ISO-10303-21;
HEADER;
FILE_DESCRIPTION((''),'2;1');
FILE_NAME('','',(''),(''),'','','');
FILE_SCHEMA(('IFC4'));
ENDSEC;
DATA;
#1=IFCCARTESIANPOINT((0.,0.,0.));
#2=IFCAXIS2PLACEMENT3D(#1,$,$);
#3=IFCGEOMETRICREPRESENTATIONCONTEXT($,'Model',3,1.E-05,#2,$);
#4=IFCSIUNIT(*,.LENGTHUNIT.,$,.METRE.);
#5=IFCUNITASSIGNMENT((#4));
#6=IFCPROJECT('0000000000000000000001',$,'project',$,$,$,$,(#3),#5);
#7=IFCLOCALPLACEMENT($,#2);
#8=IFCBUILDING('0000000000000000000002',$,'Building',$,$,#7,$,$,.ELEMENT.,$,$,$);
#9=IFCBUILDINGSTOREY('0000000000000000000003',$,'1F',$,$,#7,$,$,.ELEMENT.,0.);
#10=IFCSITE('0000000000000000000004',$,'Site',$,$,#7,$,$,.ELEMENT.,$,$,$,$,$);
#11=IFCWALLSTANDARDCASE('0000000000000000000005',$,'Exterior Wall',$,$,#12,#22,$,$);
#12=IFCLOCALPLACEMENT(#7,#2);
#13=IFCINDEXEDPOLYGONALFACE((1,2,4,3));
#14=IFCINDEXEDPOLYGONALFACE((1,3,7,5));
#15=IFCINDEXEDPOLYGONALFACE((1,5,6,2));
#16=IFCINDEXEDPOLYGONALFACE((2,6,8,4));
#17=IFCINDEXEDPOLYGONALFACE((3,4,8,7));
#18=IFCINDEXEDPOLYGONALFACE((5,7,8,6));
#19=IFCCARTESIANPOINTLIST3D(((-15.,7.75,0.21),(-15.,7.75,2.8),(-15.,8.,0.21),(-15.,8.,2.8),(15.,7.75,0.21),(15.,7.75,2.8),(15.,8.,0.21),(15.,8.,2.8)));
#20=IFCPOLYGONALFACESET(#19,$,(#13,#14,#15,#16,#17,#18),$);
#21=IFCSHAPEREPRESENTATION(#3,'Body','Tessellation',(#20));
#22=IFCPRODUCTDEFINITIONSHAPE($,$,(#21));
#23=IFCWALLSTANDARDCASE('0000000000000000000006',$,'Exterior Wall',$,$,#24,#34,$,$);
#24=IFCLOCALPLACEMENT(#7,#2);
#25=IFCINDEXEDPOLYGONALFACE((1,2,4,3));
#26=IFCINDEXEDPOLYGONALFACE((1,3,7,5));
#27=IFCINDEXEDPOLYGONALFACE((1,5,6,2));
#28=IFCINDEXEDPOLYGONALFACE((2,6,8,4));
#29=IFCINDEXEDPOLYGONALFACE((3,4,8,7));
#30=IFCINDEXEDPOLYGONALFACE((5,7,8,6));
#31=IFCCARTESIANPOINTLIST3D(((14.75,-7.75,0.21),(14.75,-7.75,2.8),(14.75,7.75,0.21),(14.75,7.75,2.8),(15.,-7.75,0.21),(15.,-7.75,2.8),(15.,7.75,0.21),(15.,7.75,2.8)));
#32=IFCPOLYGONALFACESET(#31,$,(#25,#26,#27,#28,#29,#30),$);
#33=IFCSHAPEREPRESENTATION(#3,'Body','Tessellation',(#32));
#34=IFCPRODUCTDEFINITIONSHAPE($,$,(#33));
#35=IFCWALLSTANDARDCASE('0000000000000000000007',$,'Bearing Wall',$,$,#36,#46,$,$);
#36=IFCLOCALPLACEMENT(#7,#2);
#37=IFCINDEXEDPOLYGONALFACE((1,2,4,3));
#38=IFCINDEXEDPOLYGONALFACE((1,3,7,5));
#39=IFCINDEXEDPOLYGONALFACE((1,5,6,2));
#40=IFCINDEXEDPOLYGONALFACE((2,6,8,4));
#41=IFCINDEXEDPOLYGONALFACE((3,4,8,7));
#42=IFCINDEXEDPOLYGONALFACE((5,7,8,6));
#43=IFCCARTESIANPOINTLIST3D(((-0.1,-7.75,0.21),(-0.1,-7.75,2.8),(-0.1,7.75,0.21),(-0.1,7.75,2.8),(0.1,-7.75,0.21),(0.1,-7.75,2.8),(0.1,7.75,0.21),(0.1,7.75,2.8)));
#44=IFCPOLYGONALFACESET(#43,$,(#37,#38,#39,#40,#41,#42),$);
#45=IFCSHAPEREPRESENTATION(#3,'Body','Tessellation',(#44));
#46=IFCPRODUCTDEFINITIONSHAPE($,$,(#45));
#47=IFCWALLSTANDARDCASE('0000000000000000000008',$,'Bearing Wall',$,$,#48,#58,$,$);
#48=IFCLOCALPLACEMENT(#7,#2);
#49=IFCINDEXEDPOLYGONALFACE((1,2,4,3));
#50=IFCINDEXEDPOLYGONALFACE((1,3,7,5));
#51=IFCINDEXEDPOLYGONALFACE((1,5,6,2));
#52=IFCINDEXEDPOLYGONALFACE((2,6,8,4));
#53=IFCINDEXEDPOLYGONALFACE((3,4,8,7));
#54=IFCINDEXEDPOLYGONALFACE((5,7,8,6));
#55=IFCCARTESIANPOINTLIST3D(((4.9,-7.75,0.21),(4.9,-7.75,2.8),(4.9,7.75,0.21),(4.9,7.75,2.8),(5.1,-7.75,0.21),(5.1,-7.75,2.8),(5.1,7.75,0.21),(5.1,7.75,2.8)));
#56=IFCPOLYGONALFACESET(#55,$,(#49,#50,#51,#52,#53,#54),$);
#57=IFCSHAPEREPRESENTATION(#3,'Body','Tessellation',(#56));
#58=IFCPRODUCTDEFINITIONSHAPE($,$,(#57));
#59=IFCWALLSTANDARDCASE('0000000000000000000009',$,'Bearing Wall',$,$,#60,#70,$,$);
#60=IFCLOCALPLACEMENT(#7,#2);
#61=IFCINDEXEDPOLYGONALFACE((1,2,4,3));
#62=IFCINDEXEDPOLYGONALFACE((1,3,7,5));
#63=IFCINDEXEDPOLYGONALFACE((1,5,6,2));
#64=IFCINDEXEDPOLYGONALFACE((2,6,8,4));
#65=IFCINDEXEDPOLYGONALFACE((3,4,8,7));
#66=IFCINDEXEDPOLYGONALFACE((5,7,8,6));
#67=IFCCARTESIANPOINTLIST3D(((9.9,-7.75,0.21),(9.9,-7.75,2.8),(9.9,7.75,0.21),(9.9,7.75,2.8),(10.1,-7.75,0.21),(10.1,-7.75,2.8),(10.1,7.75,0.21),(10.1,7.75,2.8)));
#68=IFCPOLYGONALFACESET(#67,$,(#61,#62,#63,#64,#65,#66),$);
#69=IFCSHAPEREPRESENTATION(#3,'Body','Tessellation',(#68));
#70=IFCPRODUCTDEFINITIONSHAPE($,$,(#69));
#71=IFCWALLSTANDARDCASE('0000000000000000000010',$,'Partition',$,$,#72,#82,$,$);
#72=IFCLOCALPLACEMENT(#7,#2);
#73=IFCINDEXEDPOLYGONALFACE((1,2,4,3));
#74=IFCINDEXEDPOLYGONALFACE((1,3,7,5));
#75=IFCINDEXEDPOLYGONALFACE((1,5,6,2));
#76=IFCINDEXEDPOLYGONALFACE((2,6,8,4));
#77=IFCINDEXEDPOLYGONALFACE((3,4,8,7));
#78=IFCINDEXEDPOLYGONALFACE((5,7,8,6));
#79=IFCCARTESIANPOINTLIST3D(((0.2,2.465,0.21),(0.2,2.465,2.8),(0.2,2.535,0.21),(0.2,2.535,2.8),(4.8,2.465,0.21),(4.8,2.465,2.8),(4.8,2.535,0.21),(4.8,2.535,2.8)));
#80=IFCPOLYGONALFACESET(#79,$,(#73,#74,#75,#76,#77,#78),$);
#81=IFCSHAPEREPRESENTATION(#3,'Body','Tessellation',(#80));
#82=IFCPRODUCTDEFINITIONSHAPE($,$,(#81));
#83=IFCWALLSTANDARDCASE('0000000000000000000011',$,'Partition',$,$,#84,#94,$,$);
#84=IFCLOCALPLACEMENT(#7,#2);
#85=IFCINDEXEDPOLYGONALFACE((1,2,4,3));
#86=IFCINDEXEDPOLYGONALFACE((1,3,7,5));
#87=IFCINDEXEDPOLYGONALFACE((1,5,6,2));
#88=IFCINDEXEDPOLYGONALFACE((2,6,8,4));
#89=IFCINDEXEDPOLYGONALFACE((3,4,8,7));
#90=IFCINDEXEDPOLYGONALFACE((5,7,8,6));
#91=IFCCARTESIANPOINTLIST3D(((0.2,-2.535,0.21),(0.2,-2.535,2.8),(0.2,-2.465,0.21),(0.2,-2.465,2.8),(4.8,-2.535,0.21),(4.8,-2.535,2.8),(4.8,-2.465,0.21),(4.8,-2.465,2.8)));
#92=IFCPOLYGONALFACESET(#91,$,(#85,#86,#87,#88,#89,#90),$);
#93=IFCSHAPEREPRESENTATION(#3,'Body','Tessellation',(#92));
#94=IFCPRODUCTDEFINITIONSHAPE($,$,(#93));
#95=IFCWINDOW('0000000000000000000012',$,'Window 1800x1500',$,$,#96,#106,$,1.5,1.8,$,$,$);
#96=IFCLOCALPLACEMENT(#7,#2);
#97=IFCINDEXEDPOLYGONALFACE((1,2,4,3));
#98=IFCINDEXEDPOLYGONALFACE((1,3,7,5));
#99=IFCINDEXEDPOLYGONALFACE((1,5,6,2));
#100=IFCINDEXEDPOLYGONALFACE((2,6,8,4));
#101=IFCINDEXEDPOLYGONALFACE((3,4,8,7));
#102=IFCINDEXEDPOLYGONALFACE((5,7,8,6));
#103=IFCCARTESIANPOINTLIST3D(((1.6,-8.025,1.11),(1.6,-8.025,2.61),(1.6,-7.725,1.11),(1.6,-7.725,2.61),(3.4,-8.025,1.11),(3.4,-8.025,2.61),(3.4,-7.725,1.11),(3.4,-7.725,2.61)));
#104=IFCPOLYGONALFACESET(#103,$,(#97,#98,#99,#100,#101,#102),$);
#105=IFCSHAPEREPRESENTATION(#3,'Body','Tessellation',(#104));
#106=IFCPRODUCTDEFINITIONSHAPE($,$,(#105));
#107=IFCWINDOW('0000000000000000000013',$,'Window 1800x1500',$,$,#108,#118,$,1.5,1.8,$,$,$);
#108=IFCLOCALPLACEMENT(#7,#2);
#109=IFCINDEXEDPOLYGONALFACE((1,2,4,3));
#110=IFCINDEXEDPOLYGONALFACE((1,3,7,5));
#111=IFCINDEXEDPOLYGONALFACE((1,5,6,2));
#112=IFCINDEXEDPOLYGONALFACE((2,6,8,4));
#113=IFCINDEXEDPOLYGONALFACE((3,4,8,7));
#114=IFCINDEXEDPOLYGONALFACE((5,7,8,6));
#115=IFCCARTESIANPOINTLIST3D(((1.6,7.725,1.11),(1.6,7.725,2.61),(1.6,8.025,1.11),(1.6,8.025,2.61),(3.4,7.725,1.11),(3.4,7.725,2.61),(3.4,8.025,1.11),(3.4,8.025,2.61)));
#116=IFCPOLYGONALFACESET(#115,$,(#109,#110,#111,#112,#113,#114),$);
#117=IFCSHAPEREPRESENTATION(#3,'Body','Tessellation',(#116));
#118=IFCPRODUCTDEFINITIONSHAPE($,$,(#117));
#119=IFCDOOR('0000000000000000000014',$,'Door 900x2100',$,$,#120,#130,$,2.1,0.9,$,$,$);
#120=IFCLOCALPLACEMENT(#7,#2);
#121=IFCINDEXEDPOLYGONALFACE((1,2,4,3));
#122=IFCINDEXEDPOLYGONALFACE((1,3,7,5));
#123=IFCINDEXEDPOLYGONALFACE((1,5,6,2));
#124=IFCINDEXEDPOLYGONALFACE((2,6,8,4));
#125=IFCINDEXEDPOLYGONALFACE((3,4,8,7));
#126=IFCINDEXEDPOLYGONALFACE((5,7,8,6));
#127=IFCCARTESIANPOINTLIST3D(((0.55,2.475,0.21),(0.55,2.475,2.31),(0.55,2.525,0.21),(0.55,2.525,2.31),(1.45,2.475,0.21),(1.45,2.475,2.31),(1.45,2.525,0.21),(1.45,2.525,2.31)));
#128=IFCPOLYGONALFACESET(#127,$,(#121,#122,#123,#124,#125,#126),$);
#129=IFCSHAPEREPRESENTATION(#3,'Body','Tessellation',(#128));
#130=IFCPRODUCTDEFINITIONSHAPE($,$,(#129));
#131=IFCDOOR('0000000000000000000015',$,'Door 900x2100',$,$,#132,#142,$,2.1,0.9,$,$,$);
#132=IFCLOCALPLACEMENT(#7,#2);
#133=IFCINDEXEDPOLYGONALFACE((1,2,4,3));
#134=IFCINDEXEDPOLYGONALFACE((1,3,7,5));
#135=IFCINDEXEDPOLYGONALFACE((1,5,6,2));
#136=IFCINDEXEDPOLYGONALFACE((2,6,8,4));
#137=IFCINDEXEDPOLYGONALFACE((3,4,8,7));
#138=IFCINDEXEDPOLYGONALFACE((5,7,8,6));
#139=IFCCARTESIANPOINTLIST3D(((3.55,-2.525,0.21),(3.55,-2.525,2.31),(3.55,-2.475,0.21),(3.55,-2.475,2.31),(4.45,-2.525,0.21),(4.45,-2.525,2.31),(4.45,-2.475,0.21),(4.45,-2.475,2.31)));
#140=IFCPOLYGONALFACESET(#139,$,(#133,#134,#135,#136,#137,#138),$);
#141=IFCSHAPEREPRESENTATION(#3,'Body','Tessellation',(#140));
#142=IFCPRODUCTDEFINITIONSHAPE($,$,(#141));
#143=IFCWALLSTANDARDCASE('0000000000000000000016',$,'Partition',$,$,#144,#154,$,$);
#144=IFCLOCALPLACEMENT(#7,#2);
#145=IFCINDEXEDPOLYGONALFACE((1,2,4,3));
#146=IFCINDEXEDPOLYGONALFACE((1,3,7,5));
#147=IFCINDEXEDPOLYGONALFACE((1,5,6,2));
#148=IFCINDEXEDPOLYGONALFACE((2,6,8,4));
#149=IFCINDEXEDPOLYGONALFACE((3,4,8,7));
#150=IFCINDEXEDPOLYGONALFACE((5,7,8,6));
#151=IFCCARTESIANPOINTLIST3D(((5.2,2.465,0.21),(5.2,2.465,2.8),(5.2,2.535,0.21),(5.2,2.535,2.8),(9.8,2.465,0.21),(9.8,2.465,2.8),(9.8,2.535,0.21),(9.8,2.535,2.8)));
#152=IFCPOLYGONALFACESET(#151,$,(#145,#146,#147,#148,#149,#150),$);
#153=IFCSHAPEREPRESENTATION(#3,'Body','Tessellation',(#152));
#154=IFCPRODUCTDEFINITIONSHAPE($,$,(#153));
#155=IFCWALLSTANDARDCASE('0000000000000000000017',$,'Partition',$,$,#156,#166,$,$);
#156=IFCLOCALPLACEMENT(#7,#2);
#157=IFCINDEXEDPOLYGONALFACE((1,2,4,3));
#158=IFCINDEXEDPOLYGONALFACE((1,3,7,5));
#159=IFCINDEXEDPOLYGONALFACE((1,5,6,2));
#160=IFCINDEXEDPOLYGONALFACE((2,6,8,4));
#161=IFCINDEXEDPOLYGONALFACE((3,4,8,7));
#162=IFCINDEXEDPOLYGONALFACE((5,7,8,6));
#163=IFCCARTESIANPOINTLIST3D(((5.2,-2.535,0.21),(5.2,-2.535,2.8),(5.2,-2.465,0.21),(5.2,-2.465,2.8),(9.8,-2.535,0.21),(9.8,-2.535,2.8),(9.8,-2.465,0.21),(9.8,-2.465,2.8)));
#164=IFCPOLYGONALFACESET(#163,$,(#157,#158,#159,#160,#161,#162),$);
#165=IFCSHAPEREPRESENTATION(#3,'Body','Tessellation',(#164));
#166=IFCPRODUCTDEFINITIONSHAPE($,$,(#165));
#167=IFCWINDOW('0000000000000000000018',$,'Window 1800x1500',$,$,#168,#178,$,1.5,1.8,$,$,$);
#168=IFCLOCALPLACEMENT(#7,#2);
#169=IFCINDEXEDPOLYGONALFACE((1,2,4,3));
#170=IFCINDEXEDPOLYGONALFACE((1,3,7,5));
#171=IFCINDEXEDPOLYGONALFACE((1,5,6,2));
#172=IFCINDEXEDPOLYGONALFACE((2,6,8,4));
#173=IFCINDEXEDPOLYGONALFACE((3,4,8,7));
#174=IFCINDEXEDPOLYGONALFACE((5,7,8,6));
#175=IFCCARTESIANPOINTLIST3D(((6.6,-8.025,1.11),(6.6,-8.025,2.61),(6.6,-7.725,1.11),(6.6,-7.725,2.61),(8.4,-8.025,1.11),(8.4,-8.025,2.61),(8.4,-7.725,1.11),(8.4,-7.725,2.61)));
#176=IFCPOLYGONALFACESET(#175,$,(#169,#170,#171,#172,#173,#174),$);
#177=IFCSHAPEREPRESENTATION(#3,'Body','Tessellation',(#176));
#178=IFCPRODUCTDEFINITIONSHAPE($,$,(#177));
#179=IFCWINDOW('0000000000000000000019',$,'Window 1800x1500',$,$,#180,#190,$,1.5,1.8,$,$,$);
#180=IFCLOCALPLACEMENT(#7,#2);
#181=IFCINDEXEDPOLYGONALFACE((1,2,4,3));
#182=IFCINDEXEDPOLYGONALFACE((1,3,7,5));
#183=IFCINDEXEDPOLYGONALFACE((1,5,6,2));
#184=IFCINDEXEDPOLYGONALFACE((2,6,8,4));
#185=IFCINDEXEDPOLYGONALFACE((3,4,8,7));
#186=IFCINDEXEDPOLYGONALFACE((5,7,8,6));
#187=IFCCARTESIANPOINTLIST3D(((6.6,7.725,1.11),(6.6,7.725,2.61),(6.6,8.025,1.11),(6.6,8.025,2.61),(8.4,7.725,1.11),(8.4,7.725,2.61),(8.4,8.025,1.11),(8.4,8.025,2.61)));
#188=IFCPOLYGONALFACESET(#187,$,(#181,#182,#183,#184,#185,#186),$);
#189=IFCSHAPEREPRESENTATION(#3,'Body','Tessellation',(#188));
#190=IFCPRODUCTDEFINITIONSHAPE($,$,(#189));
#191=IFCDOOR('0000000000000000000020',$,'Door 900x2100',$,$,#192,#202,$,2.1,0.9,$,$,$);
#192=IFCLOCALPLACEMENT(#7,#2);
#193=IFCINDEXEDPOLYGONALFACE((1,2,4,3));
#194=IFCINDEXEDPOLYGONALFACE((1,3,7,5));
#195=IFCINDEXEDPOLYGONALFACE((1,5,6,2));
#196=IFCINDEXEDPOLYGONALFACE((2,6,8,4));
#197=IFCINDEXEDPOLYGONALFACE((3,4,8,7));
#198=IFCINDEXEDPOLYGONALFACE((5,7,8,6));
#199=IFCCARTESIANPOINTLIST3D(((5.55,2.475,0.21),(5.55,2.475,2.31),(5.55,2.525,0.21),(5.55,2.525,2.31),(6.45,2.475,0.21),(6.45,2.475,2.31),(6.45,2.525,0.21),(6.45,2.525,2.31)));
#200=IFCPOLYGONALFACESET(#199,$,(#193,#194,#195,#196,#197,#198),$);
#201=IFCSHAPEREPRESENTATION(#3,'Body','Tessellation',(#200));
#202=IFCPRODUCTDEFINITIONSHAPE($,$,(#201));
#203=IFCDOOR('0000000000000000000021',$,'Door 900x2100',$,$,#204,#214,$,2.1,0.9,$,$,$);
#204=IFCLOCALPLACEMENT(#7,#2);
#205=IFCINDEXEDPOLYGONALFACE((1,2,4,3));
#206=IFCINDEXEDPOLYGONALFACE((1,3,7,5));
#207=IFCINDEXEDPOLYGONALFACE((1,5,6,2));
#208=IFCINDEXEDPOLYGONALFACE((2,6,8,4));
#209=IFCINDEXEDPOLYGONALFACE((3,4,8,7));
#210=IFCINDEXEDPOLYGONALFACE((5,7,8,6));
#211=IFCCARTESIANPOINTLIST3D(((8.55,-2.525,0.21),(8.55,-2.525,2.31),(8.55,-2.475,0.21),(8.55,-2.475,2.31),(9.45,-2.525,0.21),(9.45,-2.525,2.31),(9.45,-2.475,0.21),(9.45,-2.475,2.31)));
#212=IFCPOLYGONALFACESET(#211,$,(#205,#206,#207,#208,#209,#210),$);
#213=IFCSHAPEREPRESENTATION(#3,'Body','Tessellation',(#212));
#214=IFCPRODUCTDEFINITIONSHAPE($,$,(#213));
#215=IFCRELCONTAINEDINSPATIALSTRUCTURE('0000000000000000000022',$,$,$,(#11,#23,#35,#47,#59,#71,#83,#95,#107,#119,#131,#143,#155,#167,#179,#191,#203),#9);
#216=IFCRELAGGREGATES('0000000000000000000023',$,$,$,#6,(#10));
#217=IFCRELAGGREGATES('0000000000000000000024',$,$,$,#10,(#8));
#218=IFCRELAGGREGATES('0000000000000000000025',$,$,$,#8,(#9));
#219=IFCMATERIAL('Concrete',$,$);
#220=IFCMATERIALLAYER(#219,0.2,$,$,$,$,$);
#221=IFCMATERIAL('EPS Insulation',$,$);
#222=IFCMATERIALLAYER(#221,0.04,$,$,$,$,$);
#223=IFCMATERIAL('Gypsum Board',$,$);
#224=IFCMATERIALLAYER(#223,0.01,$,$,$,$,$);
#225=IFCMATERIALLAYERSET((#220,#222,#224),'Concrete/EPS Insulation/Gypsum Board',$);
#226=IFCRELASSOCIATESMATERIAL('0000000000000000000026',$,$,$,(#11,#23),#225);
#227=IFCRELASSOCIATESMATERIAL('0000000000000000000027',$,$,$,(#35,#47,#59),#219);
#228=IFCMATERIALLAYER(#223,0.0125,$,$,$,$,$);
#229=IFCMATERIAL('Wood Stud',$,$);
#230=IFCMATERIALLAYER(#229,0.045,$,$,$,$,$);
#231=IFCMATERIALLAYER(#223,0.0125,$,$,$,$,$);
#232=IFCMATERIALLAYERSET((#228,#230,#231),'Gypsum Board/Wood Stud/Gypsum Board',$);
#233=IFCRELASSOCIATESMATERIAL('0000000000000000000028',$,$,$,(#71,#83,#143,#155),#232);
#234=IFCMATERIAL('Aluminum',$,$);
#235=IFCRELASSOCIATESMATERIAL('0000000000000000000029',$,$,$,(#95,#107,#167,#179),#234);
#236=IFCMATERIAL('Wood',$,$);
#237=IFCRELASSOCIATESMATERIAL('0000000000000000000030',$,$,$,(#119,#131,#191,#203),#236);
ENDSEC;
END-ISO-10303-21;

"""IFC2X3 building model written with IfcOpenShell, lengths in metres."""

from ifc_helpers import new_model, si_unit, frame, origin, origin_2d, place, context, project, spatial, rectangle, extrude, material, layer, layer_set, layer_usage, element, save


model = new_model("IFC2X3")

# Units and contexts
model_context = context("Model", 3, precision=1e-05, world=origin())
ifc_project = project(units=[si_unit("LENGTHUNIT", "METRE")], contexts=[model_context])

# Site, building, storey
placement = place(None, origin())
site = spatial("IfcSite", under=ifc_project, at=placement, Name="Site", CompositionType="ELEMENT")
building = spatial("IfcBuilding", under=site, at=placement, Name="Building", CompositionType="ELEMENT")
storey = spatial("IfcBuildingStorey", under=building, at=placement, Name="1F", CompositionType="ELEMENT", Elevation=0.0)

# Walls
ifc_material_1 = material(Name="Concrete")
ifc_layer_1 = layer(ifc_material_1, 0.2)
ifc_material_2 = material(Name="EPS Insulation")
ifc_layer_2 = layer(ifc_material_2, 0.04)
ifc_material_3 = material(Name="Gypsum Board")
ifc_layer_3 = layer(ifc_material_3, 0.01)
ifc_layer_set_1 = layer_set([ifc_layer_1, ifc_layer_2, ifc_layer_3], Name="Concrete/EPS Insulation/Gypsum Board")
ifc_layer_usage_1 = layer_usage(ifc_layer_set_1, "AXIS2", "POSITIVE", 0.0)
wall_1_placement = place(None, frame((0.0, 7.875, 0.21)))
element("IfcWallStandardCase", 1, at=wall_1_placement, inside=storey, material=ifc_layer_usage_1, Name="Exterior Wall", context=model_context, shape_type="SweptSolid", body=[
    extrude(rectangle(XDim=30.0, YDim=0.25, at=origin_2d()), origin(), (0.0, 0.0, 1.0), 2.59),
])
wall_2_placement = place(None, frame((14.875, 0.0, 0.21)))
element("IfcWallStandardCase", 2, at=wall_2_placement, inside=storey, material=ifc_layer_usage_1, Name="Exterior Wall", context=model_context, shape_type="SweptSolid", body=[
    extrude(rectangle(XDim=0.25, YDim=15.5, at=origin_2d()), origin(), (0.0, 0.0, 1.0), 2.59),
])
for number, where, name in (
    (3, (0.0, 0.0, 0.21), "Bearing Wall"),
    (4, (5.0, 0.0, 0.21), "Bearing Wall"),
    (5, (10.0, 0.0, 0.21), "Bearing Wall"),
):
    element("IfcWallStandardCase", number, at=place(None, frame(where)), inside=storey, material=ifc_material_1, Name=name, context=model_context, shape_type="SweptSolid", body=[
        extrude(rectangle(XDim=0.2, YDim=15.5, at=origin_2d()), origin(), (0.0, 0.0, 1.0), 2.59),
    ])
ifc_layer_4 = layer(ifc_material_3, 0.0125)
ifc_material_4 = material(Name="Wood Stud")
ifc_layer_5 = layer(ifc_material_4, 0.045)
ifc_layer_6 = layer(ifc_material_3, 0.0125)
ifc_layer_set_2 = layer_set([ifc_layer_4, ifc_layer_5, ifc_layer_6], Name="Gypsum Board/Wood Stud/Gypsum Board")
ifc_layer_usage_2 = layer_usage(ifc_layer_set_2, "AXIS2", "POSITIVE", 0.0)
for number, where, name in (
    (6, (2.5, 2.5, 0.21), "Partition"),
    (7, (2.5, -2.5, 0.21), "Partition"),
):
    element("IfcWallStandardCase", number, at=place(None, frame(where)), inside=storey, material=ifc_layer_usage_2, Name=name, context=model_context, shape_type="SweptSolid", body=[
        extrude(rectangle(XDim=4.6, YDim=0.07, at=origin_2d()), origin(), (0.0, 0.0, 1.0), 2.59),
    ])

# Windows
ifc_material_5 = material(Name="Aluminum")
for number, where, name in (
    (8, (2.5, -7.875, 1.11), "Window 1800x1500"),
    (9, (2.5, 7.875, 1.11), "Window 1800x1500"),
):
    element("IfcWindow", number, at=place(None, frame(where)), inside=storey, material=ifc_material_5, Name=name, OverallHeight=1.5, OverallWidth=1.8, context=model_context, shape_type="SweptSolid", body=[
        extrude(rectangle(XDim=1.8, YDim=0.3, at=origin_2d()), origin(), (0.0, 0.0, 1.0), 1.5),
    ])

# Doors
ifc_material_6 = material(Name="Wood")
for number, where, name in (
    (10, (1.0, 2.5, 0.21), "Door 900x2100"),
    (11, (4.0, -2.5, 0.21), "Door 900x2100"),
):
    element("IfcDoor", number, at=place(None, frame(where)), inside=storey, material=ifc_material_6, Name=name, OverallHeight=2.1, OverallWidth=0.9, context=model_context, shape_type="SweptSolid", body=[
        extrude(rectangle(XDim=0.9, YDim=0.05, at=origin_2d()), origin(), (0.0, 0.0, 1.0), 2.1),
    ])

# Walls
for number, where, name in (
    (12, (7.5, 2.5, 0.21), "Partition"),
    (13, (7.5, -2.5, 0.21), "Partition"),
):
    element("IfcWallStandardCase", number, at=place(None, frame(where)), inside=storey, material=ifc_layer_usage_2, Name=name, context=model_context, shape_type="SweptSolid", body=[
        extrude(rectangle(XDim=4.6, YDim=0.07, at=origin_2d()), origin(), (0.0, 0.0, 1.0), 2.59),
    ])

# Windows
for number, where, name in (
    (14, (7.5, -7.875, 1.11), "Window 1800x1500"),
    (15, (7.5, 7.875, 1.11), "Window 1800x1500"),
):
    element("IfcWindow", number, at=place(None, frame(where)), inside=storey, material=ifc_material_5, Name=name, OverallHeight=1.5, OverallWidth=1.8, context=model_context, shape_type="SweptSolid", body=[
        extrude(rectangle(XDim=1.8, YDim=0.3, at=origin_2d()), origin(), (0.0, 0.0, 1.0), 1.5),
    ])

# Doors
for number, where, name in (
    (16, (6.0, 2.5, 0.21), "Door 900x2100"),
    (17, (9.0, -2.5, 0.21), "Door 900x2100"),
):
    element("IfcDoor", number, at=place(None, frame(where)), inside=storey, material=ifc_material_6, Name=name, OverallHeight=2.1, OverallWidth=0.9, context=model_context, shape_type="SweptSolid", body=[
        extrude(rectangle(XDim=0.9, YDim=0.05, at=origin_2d()), origin(), (0.0, 0.0, 1.0), 2.1),
    ])

save(model, "model.ifc")
